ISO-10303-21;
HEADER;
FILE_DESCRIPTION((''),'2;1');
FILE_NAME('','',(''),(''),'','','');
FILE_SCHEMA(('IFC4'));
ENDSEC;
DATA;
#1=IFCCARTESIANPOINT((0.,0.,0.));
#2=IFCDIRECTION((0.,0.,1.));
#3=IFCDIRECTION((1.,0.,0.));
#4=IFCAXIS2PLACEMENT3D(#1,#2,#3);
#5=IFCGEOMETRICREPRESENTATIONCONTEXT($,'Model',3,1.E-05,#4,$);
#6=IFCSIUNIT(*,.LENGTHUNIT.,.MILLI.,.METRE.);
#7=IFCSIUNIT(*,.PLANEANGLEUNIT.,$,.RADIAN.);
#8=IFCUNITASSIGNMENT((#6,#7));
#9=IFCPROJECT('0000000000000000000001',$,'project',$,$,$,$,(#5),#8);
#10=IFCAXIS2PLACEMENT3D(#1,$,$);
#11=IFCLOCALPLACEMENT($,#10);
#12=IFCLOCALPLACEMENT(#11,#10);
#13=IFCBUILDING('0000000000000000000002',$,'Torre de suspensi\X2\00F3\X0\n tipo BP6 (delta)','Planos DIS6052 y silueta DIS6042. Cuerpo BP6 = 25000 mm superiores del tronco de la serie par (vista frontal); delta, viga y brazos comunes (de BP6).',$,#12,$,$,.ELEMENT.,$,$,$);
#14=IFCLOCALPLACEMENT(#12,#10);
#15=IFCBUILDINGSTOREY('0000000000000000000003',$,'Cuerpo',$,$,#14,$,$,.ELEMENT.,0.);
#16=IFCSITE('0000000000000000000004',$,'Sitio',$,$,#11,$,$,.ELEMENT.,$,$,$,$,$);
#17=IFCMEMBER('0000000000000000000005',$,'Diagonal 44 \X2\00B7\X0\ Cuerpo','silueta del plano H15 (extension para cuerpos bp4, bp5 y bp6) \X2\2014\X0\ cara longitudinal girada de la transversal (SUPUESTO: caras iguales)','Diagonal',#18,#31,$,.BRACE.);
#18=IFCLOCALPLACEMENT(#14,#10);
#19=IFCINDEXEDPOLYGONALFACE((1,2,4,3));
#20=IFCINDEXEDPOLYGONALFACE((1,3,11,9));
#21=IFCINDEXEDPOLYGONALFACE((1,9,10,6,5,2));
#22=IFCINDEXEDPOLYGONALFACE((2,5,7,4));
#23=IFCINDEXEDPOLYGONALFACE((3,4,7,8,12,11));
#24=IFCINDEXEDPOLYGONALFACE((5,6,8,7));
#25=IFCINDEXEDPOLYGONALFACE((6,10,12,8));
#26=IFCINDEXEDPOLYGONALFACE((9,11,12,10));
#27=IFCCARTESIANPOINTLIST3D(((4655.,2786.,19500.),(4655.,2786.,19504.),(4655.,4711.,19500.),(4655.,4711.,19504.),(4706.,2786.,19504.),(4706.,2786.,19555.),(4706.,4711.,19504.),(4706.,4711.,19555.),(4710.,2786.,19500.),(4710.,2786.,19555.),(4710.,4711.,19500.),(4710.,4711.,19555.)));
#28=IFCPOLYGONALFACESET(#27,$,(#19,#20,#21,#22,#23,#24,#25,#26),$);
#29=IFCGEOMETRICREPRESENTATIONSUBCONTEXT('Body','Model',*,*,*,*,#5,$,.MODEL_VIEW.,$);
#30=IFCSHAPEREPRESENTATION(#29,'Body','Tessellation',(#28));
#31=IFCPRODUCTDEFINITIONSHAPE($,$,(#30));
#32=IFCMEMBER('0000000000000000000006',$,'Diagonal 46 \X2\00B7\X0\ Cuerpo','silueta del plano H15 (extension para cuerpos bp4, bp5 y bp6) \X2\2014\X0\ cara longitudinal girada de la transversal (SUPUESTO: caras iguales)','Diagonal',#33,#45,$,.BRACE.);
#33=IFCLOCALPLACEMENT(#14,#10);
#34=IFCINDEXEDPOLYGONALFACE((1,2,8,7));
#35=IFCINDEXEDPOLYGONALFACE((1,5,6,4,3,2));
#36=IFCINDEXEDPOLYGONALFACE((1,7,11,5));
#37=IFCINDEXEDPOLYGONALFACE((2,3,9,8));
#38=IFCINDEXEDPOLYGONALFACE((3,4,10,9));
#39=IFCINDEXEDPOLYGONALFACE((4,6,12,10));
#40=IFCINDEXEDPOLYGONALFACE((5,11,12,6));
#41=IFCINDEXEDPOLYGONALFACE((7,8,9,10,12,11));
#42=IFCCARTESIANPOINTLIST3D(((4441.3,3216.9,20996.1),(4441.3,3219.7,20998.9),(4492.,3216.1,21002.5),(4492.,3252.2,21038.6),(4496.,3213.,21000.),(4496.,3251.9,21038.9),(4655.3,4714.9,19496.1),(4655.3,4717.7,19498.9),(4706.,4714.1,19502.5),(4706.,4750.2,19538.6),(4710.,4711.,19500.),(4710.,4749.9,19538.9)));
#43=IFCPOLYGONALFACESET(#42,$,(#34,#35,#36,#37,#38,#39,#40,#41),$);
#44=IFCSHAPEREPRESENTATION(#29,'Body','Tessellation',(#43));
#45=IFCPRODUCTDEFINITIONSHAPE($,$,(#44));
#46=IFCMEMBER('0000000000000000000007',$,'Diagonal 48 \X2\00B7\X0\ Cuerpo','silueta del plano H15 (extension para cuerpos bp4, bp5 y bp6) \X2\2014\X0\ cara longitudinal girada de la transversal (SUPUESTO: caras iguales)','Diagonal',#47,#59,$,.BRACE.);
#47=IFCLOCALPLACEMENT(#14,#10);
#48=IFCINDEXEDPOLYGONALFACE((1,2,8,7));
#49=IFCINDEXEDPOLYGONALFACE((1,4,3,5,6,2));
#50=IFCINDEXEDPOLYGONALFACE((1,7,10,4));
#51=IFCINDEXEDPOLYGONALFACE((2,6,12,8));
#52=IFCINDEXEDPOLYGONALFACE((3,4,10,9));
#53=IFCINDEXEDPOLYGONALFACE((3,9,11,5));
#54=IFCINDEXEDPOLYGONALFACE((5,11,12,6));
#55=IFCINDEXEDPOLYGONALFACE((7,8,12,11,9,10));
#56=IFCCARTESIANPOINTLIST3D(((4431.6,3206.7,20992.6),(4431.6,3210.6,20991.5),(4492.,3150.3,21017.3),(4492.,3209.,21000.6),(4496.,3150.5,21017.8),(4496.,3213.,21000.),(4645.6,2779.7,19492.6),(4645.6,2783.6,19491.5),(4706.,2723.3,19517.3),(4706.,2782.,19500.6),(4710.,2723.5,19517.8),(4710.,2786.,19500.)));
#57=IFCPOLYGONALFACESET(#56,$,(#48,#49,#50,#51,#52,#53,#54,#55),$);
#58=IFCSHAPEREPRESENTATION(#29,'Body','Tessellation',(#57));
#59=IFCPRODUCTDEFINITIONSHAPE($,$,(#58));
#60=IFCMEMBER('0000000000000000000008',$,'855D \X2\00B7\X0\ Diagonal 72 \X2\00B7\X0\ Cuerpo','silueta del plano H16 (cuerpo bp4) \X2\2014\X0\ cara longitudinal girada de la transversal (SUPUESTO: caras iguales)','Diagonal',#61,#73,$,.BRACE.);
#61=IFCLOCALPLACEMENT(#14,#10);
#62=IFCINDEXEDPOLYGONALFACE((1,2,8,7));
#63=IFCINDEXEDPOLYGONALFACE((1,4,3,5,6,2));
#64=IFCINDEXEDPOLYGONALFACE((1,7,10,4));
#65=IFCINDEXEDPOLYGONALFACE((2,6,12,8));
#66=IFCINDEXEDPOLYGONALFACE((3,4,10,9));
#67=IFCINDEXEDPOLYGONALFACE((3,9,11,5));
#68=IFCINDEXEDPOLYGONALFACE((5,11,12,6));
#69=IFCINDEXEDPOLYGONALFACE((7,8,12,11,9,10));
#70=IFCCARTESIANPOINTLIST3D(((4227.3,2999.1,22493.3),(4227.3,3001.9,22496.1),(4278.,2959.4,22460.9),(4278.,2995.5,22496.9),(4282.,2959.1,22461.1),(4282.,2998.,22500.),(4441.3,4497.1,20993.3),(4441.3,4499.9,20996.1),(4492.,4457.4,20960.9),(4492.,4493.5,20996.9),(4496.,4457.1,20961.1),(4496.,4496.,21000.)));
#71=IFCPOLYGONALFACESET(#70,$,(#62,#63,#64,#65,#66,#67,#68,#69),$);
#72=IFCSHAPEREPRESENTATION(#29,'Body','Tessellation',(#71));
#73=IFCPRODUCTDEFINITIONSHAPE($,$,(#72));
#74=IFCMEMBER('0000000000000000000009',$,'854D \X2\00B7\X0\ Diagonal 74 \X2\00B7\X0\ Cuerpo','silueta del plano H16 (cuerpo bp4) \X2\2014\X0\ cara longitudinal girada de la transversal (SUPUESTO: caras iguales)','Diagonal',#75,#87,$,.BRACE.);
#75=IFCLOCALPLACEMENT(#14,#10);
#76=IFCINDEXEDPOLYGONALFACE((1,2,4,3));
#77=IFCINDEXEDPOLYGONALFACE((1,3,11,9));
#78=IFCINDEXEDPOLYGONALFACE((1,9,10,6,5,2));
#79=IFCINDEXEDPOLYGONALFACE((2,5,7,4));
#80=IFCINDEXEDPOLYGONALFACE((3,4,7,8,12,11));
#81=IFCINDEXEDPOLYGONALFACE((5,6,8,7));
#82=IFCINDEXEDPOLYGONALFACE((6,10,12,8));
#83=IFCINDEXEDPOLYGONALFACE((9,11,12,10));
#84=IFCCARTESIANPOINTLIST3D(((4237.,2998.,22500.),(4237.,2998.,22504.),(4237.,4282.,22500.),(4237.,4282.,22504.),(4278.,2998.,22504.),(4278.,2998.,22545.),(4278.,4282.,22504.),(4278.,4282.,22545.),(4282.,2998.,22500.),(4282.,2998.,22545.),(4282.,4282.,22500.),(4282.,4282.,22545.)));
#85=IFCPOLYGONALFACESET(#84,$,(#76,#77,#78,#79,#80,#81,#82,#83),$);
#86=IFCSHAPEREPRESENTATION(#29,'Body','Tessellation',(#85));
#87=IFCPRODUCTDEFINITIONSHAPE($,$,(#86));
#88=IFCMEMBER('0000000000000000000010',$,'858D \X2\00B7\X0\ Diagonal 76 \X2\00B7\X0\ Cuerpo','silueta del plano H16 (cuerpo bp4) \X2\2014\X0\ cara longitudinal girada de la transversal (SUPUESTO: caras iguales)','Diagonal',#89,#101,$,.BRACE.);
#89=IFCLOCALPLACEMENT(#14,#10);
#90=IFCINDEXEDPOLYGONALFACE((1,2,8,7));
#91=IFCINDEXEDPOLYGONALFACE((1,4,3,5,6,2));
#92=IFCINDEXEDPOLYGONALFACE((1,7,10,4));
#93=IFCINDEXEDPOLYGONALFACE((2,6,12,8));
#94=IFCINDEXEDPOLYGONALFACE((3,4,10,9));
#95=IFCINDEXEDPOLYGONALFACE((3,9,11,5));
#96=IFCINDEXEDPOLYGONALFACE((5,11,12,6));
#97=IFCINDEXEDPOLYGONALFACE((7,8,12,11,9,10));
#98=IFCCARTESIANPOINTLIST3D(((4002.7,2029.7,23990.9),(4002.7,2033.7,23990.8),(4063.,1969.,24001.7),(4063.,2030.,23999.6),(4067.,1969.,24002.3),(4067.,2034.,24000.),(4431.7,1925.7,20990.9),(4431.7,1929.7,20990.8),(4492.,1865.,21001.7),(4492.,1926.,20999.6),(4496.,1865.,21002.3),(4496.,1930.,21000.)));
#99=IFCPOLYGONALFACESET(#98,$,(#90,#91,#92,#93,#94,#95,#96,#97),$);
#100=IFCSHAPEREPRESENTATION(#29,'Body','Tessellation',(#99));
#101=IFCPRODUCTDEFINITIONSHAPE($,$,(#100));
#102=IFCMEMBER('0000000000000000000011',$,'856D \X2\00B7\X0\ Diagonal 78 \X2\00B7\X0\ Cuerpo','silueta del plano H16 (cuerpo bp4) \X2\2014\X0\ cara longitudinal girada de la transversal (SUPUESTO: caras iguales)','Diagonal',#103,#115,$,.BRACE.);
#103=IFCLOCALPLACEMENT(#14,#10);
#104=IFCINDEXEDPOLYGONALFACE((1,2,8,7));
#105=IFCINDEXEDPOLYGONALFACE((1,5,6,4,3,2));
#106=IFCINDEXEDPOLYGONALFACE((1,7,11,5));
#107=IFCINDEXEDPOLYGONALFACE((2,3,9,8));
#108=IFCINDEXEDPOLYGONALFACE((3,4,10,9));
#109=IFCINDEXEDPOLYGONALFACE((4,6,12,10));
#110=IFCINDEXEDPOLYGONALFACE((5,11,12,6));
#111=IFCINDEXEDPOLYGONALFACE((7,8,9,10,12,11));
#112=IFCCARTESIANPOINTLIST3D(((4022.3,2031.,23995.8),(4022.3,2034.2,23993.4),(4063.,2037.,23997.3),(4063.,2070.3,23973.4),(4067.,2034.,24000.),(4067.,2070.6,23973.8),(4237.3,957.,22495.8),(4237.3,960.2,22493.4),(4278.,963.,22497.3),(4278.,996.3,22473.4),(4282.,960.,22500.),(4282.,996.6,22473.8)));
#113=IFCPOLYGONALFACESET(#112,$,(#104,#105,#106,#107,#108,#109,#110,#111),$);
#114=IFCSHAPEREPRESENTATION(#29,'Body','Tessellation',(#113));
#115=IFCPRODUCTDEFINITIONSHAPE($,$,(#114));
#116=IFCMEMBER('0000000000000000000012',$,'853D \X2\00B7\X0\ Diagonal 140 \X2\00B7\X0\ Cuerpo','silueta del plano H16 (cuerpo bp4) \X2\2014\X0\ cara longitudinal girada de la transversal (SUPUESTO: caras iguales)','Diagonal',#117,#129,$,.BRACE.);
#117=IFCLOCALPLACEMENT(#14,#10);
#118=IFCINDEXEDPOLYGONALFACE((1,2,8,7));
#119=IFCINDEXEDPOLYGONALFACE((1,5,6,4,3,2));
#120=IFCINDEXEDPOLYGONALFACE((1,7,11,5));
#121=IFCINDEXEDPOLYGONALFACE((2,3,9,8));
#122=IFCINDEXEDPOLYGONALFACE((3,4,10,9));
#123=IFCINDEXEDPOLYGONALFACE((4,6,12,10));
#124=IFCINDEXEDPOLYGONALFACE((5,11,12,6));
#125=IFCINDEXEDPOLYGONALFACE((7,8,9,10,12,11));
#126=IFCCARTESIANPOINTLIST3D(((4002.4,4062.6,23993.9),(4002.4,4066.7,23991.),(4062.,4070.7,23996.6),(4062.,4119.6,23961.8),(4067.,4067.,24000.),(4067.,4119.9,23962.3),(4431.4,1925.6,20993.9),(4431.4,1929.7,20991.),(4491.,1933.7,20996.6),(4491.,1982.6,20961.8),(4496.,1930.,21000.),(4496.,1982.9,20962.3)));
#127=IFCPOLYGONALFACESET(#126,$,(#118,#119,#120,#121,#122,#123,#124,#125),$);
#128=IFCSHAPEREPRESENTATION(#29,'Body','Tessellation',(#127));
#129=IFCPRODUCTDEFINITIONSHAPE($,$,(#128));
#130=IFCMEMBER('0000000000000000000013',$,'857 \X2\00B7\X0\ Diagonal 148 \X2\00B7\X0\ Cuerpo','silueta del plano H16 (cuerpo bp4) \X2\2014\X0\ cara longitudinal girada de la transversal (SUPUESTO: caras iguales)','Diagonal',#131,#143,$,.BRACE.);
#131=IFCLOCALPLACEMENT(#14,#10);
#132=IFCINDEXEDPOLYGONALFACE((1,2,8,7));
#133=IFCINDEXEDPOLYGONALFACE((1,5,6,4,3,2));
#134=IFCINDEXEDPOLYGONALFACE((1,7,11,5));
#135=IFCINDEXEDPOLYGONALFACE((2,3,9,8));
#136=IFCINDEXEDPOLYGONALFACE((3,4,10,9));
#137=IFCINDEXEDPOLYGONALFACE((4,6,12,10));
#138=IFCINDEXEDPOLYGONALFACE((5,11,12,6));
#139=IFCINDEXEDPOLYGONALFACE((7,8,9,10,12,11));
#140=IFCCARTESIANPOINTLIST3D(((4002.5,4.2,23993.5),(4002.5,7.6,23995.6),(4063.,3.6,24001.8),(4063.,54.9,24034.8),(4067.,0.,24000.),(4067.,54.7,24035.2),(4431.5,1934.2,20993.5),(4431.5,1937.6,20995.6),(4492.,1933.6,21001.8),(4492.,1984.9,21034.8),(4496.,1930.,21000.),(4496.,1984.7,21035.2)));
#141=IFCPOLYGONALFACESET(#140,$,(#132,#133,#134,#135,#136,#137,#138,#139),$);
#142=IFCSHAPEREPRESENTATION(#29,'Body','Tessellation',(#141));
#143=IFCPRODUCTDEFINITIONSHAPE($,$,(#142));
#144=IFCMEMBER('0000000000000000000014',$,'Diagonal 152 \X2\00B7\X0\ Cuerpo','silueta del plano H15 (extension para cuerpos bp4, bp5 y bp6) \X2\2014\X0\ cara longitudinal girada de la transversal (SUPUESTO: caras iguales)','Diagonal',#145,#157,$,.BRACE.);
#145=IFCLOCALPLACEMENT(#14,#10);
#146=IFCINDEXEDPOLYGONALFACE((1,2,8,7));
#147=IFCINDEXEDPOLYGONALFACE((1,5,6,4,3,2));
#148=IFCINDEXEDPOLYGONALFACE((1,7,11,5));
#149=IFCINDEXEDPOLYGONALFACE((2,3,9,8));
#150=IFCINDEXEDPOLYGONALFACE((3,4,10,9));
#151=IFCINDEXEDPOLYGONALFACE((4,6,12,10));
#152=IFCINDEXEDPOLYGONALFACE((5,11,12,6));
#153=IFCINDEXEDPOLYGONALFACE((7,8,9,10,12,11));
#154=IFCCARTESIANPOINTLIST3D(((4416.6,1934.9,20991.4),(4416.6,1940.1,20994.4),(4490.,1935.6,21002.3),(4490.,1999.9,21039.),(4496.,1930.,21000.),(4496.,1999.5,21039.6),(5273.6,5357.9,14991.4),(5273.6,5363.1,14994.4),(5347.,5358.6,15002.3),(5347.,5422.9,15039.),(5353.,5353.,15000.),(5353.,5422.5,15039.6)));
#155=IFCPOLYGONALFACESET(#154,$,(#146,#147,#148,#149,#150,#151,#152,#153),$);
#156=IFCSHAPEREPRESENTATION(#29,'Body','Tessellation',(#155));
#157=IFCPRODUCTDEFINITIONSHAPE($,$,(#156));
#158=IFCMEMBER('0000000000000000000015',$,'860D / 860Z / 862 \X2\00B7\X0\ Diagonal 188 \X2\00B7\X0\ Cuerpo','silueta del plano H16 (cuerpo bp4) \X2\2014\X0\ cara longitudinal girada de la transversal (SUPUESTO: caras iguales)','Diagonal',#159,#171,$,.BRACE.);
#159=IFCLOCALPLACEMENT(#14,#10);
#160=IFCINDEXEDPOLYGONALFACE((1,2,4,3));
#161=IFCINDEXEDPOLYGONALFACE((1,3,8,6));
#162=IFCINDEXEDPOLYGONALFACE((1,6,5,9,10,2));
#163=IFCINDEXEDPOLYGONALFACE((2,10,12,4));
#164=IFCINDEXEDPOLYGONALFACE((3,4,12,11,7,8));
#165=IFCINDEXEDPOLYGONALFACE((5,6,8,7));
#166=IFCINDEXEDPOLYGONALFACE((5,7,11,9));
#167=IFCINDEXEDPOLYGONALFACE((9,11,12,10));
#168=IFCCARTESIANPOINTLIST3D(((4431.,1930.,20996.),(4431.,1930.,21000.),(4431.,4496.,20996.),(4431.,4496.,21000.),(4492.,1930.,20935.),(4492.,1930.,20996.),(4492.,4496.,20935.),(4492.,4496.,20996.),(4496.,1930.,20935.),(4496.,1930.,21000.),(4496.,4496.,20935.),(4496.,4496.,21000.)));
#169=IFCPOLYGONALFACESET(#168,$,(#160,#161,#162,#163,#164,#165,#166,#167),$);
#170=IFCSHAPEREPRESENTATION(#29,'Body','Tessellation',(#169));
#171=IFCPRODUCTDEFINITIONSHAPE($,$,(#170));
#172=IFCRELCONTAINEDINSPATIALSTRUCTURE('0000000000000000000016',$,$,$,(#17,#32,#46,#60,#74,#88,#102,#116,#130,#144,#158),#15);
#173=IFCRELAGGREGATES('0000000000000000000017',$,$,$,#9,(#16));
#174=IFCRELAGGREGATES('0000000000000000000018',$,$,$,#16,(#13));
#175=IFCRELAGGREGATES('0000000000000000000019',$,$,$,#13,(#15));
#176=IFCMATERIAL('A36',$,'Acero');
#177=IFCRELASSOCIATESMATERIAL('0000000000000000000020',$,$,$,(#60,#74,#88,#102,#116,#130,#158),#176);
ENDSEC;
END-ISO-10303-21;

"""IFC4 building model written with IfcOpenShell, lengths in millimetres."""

from ifc_helpers import new_model, si_unit, frame, frame_2d, origin, origin_with_axes, place, context, subcontext, project, spatial, l_section, extrude, material, element, save


model = new_model("IFC4")

# Units and contexts
model_context = context("Model", 3, precision=1e-05, world=origin_with_axes())
body_context = subcontext(model_context, "Body", "Model", "MODEL_VIEW")
ifc_project = project(units=[si_unit("LENGTHUNIT", "METRE", prefix="MILLI"), si_unit("PLANEANGLEUNIT", "RADIAN")], contexts=[model_context])

# Site, building, storey
site_placement = place(None, origin())
site = spatial("IfcSite", under=ifc_project, at=site_placement, Name="Sitio", CompositionType="ELEMENT")
building_placement = place(site_placement, origin())
building = spatial("IfcBuilding", under=site, at=building_placement, Name="Torre de suspensión tipo BP6 (delta)", Description="Planos DIS6052 y silueta DIS6042. Cuerpo BP6 = 25000 mm superiores del tronco de la serie par (vista frontal); delta, viga y brazos comunes (de BP6).", CompositionType="ELEMENT")
storey_placement = place(building_placement, origin())
storey = spatial("IfcBuildingStorey", under=building, at=storey_placement, Name="Cuerpo", CompositionType="ELEMENT", Elevation=0.0)

# Members
ifc_material_1 = material(Name="A36", Category="Acero")
member_1_placement = place(storey_placement, frame((4710.0, 2786.0, 19500.0), z_axis=(0.0, 1.0, 0.0), x_axis=(-1.0, 0.0, 0.0)))
element("IfcMember", 1, at=member_1_placement, inside=storey, Name="Diagonal 44 · Cuerpo", Description="silueta del plano H15 (extension para cuerpos bp4, bp5 y bp6) — cara longitudinal girada de la transversal (SUPUESTO: caras iguales)", ObjectType="Diagonal", PredefinedType="BRACE", context=body_context, shape_type="SweptSolid", body=[
    extrude(l_section(Depth=55.0, Width=55.0, Thickness=4.0, at=frame_2d((27.5, 27.5))), None, (0.0, 0.0, 1.0), 1925.0),
])
member_2_placement = place(storey_placement, frame((4496.0, 3213.0, 21000.0), z_axis=(0.100437, 0.703062, -0.704), x_axis=(-0.994943, 0.070973, -0.071067)))
element("IfcMember", 2, at=member_2_placement, inside=storey, Name="Diagonal 46 · Cuerpo", Description="silueta del plano H15 (extension para cuerpos bp4, bp5 y bp6) — cara longitudinal girada de la transversal (SUPUESTO: caras iguales)", ObjectType="Diagonal", PredefinedType="BRACE", context=body_context, shape_type="SweptSolid", body=[
    extrude(l_section(Depth=55.0, Width=55.0, Thickness=4.0, at=frame_2d((27.5, 27.5))), None, (0.0, 0.0, 1.0), 2130.7),
])
member_3_placement = place(storey_placement, frame((4710.0, 2786.0, 19500.0), z_axis=(-0.135942, 0.271248, 0.952861), x_axis=(-0.990717, -0.037219, -0.130747)))
element("IfcMember", 3, at=member_3_placement, inside=storey, Name="Diagonal 48 · Cuerpo", Description="silueta del plano H15 (extension para cuerpos bp4, bp5 y bp6) — cara longitudinal girada de la transversal (SUPUESTO: caras iguales)", ObjectType="Diagonal", PredefinedType="BRACE", context=body_context, shape_type="SweptSolid", body=[
    extrude(l_section(Depth=65.0, Width=65.0, Thickness=4.0, at=frame_2d((32.5, 32.5))), None, (0.0, 0.0, 1.0), 1574.2),
])
member_4_placement = place(storey_placement, frame((4496.0, 4496.0, 21000.0), z_axis=(-0.100437, -0.703062, 0.704), x_axis=(-0.994943, 0.070973, -0.071067)))
element("IfcMember", 4, at=member_4_placement, inside=storey, material=ifc_material_1, Name="855D · Diagonal 72 · Cuerpo", Description="silueta del plano H16 (cuerpo bp4) — cara longitudinal girada de la transversal (SUPUESTO: caras iguales)", ObjectType="Diagonal", PredefinedType="BRACE", context=body_context, shape_type="SweptSolid", body=[
    extrude(l_section(Depth=55.0, Width=55.0, Thickness=4.0, at=frame_2d((27.5, 27.5))), None, (0.0, 0.0, 1.0), 2130.7),
])
member_5_placement = place(storey_placement, frame((4282.0, 2998.0, 22500.0), z_axis=(0.0, 1.0, 0.0), x_axis=(-1.0, 0.0, 0.0)))
element("IfcMember", 5, at=member_5_placement, inside=storey, material=ifc_material_1, Name="854D · Diagonal 74 · Cuerpo", Description="silueta del plano H16 (cuerpo bp4) — cara longitudinal girada de la transversal (SUPUESTO: caras iguales)", ObjectType="Diagonal", PredefinedType="BRACE", context=body_context, shape_type="SweptSolid", body=[
    extrude(l_section(Depth=45.0, Width=45.0, Thickness=4.0, at=frame_2d((22.5, 22.5))), None, (0.0, 0.0, 1.0), 1284.0),
])
member_6_placement = place(storey_placement, frame((4496.0, 1930.0, 21000.0), z_axis=(-0.141477, 0.034297, 0.989347), x_axis=(-0.989942, -0.004902, -0.141392)))
element("IfcMember", 6, at=member_6_placement, inside=storey, material=ifc_material_1, Name="858D · Diagonal 76 · Cuerpo", Description="silueta del plano H16 (cuerpo bp4) — cara longitudinal girada de la transversal (SUPUESTO: caras iguales)", ObjectType="Diagonal", PredefinedType="BRACE", context=body_context, shape_type="SweptSolid", body=[
    extrude(l_section(Depth=65.0, Width=65.0, Thickness=4.0, at=frame_2d((32.5, 32.5))), None, (0.0, 0.0, 1.0), 3032.3),
])
member_7_placement = place(storey_placement, frame((4067.0, 2034.0, 24000.0), z_axis=(0.115757, -0.578247, -0.807608), x_axis=(-0.993278, -0.067389, -0.094119)))
element("IfcMember", 7, at=member_7_placement, inside=storey, material=ifc_material_1, Name="856D · Diagonal 78 · Cuerpo", Description="silueta del plano H16 (cuerpo bp4) — cara longitudinal girada de la transversal (SUPUESTO: caras iguales)", ObjectType="Diagonal", PredefinedType="BRACE", context=body_context, shape_type="SweptSolid", body=[
    extrude(l_section(Depth=45.0, Width=45.0, Thickness=4.0, at=frame_2d((22.5, 22.5))), None, (0.0, 0.0, 1.0), 1857.3),
])
member_8_placement = place(storey_placement, frame((4067.0, 4067.0, 24000.0), z_axis=(0.115689, -0.576289, -0.809016), x_axis=(-0.993285, -0.067121, -0.094227)))
element("IfcMember", 8, at=member_8_placement, inside=storey, material=ifc_material_1, Name="853D · Diagonal 140 · Cuerpo", Description="silueta del plano H16 (cuerpo bp4) — cara longitudinal girada de la transversal (SUPUESTO: caras iguales)", ObjectType="Diagonal", PredefinedType="BRACE", context=body_context, shape_type="SweptSolid", body=[
    extrude(l_section(Depth=65.0, Width=65.0, Thickness=5.0, at=frame_2d((32.5, 32.5))), None, (0.0, 0.0, 1.0), 3708.2),
])
member_9_placement = place(storey_placement, frame((4067.0, 0.0, 24000.0), z_axis=(0.119402, 0.53717, -0.83498), x_axis=(-0.992846, 0.064601, -0.100417)))
element("IfcMember", 9, at=member_9_placement, inside=storey, material=ifc_material_1, Name="857 · Diagonal 148 · Cuerpo", Description="silueta del plano H16 (cuerpo bp4) — cara longitudinal girada de la transversal (SUPUESTO: caras iguales)", ObjectType="Diagonal", PredefinedType="BRACE", context=body_context, shape_type="SweptSolid", body=[
    extrude(l_section(Depth=65.0, Width=65.0, Thickness=4.0, at=frame_2d((32.5, 32.5))), None, (0.0, 0.0, 1.0), 3592.9),
])
member_10_placement = place(storey_placement, frame((4496.0, 1930.0, 21000.0), z_axis=(0.12312, 0.491761, -0.861982), x_axis=(-0.992392, 0.06101, -0.106941)))
element("IfcMember", 10, at=member_10_placement, inside=storey, Name="Diagonal 152 · Cuerpo", Description="silueta del plano H15 (extension para cuerpos bp4, bp5 y bp6) — cara longitudinal girada de la transversal (SUPUESTO: caras iguales)", ObjectType="Diagonal", PredefinedType="BRACE", context=body_context, shape_type="SweptSolid", body=[
    extrude(l_section(Depth=80.0, Width=80.0, Thickness=6.0, at=frame_2d((40.0, 40.0))), None, (0.0, 0.0, 1.0), 6960.7),
])
member_11_placement = place(storey_placement, frame((4496.0, 4496.0, 21000.0), z_axis=(0.0, -1.0, 0.0), x_axis=(-1.0, 0.0, 0.0)))
element("IfcMember", 11, at=member_11_placement, inside=storey, material=ifc_material_1, Name="860D / 860Z / 862 · Diagonal 188 · Cuerpo", Description="silueta del plano H16 (cuerpo bp4) — cara longitudinal girada de la transversal (SUPUESTO: caras iguales)", ObjectType="Diagonal", PredefinedType="BRACE", context=body_context, shape_type="SweptSolid", body=[
    extrude(l_section(Depth=65.0, Width=65.0, Thickness=4.0, at=frame_2d((32.5, 32.5))), None, (0.0, 0.0, 1.0), 2566.0),
])

save(model, "model.ifc")
